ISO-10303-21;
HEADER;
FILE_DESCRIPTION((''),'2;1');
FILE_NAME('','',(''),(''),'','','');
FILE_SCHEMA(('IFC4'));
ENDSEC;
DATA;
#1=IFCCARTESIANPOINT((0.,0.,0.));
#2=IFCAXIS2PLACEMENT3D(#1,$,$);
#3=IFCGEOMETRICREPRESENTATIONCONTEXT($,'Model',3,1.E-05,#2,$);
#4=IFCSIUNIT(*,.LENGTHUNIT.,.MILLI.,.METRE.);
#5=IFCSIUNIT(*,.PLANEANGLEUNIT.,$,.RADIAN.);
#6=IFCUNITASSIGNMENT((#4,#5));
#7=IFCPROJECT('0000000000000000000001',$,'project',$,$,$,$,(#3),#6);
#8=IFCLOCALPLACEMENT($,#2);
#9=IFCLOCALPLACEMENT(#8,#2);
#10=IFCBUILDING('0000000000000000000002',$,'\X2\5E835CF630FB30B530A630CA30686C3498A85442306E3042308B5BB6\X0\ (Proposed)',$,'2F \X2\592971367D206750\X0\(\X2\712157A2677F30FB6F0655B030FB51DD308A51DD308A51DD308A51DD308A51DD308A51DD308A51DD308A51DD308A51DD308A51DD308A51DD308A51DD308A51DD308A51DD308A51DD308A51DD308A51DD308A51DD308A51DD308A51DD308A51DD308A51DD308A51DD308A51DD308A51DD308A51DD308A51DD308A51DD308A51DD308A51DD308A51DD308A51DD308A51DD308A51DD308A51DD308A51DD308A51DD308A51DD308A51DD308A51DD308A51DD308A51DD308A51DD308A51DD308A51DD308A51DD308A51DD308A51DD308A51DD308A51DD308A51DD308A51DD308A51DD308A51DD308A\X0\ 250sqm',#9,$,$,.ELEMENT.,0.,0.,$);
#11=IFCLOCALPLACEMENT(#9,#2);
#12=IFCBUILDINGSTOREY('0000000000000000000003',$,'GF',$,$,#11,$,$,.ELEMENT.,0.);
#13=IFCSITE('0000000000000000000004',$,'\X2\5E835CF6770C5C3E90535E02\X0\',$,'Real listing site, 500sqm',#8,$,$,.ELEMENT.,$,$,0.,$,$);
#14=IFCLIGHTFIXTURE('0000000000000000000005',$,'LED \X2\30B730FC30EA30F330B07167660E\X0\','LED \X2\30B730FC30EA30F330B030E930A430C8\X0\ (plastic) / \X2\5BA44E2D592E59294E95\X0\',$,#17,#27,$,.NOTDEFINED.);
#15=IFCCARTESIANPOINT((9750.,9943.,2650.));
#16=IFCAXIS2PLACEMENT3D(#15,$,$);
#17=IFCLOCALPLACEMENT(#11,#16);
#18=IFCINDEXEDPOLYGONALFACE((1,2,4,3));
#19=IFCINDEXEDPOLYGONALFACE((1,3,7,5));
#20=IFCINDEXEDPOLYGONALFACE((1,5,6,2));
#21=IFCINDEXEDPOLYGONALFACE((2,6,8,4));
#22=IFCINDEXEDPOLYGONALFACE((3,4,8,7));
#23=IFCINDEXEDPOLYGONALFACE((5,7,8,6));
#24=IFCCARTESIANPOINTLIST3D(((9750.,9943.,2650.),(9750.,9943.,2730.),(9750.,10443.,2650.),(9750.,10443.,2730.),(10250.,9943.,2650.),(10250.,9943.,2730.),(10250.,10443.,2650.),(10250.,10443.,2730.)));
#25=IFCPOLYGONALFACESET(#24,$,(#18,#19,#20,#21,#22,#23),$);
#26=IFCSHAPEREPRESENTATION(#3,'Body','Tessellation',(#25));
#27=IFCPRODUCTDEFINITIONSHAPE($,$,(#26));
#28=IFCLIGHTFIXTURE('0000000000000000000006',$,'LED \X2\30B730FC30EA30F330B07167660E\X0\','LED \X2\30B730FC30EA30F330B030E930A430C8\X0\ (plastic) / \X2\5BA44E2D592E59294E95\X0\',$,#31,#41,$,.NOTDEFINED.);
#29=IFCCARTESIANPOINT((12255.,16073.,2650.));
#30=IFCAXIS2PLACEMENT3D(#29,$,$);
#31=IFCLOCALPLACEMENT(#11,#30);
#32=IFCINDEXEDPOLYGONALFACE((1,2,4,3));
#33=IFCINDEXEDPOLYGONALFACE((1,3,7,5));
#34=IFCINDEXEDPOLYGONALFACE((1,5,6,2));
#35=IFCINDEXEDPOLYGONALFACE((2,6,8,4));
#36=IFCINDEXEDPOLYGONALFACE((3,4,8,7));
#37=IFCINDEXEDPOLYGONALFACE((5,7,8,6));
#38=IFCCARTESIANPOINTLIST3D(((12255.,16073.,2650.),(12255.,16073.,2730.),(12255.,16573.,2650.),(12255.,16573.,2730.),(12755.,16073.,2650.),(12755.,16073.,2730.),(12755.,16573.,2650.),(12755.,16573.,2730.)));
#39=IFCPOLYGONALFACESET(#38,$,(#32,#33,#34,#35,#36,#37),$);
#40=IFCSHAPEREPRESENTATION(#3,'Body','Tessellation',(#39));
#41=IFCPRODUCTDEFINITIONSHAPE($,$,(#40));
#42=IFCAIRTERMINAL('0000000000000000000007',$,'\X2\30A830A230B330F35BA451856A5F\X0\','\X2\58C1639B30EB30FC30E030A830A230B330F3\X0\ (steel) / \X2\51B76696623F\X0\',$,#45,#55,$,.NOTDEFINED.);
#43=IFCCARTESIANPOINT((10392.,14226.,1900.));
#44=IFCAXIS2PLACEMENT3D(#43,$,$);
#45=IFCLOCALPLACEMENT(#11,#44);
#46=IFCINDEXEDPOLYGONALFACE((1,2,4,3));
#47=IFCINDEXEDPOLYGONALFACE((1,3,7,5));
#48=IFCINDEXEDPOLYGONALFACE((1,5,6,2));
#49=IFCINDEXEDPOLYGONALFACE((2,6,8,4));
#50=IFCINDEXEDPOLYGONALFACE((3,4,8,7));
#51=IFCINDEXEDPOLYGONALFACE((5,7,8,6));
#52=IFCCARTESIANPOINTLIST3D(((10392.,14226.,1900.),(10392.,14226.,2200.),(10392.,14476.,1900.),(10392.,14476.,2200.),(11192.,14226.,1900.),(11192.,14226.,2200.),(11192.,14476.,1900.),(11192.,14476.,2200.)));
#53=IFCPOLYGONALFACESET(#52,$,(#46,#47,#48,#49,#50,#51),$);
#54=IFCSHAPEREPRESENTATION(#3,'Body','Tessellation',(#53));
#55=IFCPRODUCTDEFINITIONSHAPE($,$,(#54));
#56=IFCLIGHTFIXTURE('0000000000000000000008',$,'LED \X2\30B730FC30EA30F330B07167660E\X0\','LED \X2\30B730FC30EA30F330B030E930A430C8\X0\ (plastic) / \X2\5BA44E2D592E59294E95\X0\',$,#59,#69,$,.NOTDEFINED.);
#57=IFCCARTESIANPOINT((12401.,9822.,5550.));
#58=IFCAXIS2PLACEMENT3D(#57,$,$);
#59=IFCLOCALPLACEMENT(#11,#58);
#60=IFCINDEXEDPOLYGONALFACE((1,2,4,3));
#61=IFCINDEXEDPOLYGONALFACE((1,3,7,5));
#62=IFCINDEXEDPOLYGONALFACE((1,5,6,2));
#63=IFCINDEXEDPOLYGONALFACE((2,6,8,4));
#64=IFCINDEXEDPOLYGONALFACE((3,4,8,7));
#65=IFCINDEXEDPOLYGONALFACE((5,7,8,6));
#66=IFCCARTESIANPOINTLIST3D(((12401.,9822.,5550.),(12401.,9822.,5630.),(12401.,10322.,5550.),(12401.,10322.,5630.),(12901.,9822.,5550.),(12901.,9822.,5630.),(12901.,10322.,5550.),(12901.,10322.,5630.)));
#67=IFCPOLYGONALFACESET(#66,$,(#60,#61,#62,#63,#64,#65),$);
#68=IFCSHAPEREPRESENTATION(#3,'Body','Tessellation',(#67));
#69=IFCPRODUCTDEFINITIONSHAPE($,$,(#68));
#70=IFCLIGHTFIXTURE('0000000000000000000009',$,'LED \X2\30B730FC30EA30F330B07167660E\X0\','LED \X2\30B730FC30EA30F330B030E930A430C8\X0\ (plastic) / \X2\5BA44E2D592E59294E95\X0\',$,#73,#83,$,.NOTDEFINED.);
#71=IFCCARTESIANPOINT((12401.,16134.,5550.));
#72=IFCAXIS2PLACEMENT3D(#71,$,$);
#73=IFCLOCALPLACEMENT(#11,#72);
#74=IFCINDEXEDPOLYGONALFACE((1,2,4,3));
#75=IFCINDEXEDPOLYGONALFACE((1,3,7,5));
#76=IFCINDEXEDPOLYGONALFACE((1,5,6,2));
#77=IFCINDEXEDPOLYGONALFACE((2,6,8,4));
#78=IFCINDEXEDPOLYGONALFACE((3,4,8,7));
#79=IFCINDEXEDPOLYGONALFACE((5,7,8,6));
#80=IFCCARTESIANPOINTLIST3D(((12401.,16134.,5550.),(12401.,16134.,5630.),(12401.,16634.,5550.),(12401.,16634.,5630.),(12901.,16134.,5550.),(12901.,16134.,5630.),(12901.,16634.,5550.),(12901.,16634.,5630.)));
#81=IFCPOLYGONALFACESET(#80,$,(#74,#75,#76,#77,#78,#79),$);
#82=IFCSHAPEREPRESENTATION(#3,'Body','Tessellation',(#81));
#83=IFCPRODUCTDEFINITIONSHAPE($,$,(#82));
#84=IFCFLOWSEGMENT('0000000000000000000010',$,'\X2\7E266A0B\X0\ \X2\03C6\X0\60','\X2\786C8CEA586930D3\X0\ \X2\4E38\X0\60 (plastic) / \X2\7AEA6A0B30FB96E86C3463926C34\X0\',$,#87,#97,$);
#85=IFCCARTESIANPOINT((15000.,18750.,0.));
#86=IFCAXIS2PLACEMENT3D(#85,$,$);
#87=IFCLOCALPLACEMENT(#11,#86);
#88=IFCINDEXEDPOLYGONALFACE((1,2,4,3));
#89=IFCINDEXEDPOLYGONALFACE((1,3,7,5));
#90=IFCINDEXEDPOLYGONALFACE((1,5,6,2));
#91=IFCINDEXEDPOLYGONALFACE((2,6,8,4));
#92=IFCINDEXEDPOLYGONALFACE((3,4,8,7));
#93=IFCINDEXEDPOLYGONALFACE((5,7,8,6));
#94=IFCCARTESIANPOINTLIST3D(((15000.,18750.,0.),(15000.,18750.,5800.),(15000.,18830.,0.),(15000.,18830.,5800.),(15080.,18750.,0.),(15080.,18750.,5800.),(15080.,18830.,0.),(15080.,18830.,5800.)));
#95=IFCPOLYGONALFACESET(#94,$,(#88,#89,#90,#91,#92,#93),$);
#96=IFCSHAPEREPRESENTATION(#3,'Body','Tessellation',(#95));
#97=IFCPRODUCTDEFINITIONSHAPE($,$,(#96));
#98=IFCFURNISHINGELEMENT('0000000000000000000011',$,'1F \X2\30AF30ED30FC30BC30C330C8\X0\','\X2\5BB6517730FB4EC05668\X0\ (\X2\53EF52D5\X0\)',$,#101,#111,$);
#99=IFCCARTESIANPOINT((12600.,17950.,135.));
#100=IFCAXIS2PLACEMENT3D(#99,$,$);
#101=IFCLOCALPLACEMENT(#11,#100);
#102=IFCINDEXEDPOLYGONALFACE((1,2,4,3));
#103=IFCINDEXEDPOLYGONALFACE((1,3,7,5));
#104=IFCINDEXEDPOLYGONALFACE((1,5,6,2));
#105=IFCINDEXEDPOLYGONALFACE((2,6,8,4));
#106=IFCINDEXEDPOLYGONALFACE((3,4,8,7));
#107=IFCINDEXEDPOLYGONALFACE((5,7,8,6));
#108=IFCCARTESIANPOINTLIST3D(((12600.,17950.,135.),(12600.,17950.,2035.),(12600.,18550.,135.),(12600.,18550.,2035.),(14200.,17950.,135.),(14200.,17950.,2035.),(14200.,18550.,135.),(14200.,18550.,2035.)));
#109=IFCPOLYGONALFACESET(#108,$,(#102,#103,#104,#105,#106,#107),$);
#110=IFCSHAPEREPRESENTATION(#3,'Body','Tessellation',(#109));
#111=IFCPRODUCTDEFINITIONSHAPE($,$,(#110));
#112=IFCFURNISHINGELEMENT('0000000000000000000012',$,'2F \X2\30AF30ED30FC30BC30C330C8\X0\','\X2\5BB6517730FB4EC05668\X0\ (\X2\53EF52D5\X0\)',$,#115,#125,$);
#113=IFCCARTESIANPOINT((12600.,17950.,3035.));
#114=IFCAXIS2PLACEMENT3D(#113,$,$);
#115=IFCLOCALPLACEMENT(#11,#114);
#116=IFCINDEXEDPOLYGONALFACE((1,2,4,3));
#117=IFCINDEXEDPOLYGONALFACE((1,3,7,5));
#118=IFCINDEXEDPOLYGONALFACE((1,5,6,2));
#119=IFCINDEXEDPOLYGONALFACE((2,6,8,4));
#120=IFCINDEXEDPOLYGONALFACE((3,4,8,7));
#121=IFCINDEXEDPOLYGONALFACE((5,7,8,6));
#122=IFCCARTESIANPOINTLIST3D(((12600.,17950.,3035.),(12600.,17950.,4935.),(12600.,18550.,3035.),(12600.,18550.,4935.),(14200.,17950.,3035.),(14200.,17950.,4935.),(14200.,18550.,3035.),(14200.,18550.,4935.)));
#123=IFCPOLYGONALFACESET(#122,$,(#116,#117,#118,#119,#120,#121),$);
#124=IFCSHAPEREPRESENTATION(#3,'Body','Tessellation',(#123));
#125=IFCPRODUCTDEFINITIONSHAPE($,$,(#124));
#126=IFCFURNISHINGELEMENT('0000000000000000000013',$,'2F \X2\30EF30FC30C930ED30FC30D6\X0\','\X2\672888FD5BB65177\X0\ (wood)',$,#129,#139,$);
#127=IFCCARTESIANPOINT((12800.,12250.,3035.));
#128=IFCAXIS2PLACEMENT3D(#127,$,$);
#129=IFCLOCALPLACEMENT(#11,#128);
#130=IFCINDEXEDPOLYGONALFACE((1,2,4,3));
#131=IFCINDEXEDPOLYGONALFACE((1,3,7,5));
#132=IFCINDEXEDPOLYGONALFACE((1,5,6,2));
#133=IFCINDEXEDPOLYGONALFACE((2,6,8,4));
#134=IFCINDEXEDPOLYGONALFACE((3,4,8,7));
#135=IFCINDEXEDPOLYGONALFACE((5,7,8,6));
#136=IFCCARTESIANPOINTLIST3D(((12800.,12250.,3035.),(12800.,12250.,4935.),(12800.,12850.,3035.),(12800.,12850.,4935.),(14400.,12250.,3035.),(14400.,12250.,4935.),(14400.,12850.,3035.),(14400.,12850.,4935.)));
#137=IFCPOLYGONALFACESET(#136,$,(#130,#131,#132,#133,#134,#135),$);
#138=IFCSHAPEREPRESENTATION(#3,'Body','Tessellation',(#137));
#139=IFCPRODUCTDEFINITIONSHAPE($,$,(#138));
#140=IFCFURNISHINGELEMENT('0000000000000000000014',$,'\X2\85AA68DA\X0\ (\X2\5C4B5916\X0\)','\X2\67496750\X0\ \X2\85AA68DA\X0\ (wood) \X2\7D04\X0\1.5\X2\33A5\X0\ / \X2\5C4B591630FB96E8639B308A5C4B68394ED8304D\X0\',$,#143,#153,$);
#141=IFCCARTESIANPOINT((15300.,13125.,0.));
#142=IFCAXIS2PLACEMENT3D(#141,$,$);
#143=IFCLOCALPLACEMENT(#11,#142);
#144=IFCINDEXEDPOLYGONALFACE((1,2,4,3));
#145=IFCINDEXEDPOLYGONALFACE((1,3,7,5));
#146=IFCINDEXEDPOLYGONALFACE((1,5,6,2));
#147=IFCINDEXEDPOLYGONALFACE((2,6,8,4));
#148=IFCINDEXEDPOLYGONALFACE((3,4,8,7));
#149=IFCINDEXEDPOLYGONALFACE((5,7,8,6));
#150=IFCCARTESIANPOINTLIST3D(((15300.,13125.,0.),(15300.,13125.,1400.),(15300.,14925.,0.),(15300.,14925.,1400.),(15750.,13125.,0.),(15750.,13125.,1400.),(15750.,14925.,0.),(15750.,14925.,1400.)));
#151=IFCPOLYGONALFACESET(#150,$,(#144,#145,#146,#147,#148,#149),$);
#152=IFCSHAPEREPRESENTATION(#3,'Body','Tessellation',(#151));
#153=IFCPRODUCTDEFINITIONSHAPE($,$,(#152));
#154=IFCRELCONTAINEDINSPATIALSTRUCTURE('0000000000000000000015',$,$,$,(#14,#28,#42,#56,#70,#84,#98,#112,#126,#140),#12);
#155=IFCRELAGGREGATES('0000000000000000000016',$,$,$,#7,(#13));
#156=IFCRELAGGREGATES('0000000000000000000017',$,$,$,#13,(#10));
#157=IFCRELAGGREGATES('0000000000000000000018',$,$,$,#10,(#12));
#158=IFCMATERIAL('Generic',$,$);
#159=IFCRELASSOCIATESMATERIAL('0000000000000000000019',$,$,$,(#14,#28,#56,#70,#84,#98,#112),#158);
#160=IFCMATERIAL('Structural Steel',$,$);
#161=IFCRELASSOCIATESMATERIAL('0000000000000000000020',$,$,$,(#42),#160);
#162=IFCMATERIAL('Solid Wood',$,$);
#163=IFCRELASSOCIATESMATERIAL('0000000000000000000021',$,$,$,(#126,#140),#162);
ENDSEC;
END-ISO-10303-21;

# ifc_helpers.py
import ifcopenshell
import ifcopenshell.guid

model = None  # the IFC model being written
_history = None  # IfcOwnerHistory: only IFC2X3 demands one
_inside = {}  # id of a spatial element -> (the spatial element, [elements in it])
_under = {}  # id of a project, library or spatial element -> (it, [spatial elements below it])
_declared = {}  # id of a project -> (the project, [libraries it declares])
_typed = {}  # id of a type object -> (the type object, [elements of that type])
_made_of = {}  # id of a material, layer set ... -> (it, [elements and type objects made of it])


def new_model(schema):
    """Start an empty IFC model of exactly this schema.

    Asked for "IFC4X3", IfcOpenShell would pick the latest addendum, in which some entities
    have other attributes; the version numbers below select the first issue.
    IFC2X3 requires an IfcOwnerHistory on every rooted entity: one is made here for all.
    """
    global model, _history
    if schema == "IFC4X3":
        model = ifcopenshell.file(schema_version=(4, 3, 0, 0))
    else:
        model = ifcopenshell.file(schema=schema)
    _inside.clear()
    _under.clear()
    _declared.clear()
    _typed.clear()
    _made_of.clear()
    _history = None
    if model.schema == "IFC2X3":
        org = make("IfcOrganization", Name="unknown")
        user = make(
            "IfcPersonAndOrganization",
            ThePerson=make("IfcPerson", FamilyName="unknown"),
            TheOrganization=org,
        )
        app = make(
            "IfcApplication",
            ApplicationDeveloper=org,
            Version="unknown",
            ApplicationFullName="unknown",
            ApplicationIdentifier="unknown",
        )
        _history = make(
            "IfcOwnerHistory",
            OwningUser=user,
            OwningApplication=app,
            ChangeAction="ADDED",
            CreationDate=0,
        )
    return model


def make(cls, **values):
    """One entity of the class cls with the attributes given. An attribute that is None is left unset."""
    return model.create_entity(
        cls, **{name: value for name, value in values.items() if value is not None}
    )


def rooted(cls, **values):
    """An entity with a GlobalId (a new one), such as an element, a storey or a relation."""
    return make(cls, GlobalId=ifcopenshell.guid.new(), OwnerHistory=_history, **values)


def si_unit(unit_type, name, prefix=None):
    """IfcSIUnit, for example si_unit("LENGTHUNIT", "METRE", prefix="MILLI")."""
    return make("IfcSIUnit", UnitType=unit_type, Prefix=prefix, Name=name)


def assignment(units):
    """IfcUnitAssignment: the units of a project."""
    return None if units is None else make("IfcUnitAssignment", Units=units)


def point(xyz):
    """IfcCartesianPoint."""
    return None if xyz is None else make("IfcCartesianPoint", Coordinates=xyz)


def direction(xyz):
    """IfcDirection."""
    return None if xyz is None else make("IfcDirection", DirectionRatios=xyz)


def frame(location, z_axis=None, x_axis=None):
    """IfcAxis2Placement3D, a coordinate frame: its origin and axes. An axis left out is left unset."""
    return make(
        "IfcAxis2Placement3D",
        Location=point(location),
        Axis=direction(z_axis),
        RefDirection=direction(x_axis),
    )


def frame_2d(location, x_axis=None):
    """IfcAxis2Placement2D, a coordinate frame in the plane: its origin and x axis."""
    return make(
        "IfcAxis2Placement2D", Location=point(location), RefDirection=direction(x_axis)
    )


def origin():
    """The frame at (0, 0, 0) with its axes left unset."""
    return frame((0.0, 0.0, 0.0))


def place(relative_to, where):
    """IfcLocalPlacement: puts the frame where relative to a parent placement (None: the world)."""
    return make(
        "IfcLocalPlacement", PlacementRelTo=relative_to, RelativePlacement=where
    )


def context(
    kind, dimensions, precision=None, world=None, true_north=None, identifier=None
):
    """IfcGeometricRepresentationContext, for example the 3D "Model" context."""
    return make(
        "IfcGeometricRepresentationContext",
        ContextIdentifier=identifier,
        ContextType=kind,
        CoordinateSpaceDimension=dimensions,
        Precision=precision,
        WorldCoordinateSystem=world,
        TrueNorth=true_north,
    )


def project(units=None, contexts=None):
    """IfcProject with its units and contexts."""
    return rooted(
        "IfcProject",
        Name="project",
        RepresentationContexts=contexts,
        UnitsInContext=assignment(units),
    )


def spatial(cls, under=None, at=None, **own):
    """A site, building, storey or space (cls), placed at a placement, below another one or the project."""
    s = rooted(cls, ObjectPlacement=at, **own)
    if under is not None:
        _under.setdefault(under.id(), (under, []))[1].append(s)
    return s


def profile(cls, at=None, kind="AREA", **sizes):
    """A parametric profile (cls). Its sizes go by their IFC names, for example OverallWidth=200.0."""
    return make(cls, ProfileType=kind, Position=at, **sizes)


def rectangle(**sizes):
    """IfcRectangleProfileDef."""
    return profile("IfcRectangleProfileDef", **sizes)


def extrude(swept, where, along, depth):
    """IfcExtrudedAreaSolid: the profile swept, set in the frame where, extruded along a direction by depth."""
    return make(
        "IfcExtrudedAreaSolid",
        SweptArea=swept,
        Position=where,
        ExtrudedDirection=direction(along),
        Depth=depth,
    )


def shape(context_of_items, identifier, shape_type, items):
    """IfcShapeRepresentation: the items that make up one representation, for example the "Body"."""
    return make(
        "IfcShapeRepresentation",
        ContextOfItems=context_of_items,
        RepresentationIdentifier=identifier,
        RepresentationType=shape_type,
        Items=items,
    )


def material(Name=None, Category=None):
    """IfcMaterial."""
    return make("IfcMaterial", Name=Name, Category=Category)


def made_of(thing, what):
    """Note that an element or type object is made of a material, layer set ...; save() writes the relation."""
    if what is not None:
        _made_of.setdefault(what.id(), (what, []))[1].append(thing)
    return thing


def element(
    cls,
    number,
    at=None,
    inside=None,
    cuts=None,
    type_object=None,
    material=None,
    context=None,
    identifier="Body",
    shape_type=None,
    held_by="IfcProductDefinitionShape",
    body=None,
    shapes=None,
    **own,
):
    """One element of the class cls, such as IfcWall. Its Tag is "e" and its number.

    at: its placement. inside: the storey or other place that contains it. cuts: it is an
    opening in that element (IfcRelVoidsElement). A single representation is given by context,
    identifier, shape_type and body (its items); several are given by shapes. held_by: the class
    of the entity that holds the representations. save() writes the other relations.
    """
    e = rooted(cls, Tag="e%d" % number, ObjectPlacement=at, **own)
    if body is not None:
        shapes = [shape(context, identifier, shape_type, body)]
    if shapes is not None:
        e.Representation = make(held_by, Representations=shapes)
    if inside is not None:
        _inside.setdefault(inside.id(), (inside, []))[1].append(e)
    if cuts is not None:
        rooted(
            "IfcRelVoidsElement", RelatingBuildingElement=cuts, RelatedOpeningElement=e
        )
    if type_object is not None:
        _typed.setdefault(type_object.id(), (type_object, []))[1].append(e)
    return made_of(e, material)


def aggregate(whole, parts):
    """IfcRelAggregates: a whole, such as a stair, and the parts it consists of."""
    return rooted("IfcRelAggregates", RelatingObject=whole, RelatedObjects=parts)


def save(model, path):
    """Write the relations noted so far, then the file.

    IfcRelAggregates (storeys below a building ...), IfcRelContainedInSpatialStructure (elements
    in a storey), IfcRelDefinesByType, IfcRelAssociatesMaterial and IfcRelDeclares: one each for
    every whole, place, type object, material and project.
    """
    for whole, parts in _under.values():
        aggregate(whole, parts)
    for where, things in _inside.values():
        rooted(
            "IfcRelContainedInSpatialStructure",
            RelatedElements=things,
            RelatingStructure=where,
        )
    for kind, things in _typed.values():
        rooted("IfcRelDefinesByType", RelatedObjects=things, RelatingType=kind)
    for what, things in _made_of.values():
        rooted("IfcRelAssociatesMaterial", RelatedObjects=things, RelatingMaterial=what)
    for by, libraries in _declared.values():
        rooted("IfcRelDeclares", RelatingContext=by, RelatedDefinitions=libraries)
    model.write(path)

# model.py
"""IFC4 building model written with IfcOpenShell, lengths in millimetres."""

from ifc_helpers import new_model, si_unit, frame, frame_2d, origin, place, context, project, spatial, rectangle, extrude, material, element, save


model = new_model("IFC4")

# Units and contexts
model_context = context("Model", 3, precision=1e-05, world=origin())
ifc_project = project(units=[si_unit("LENGTHUNIT", "METRE", prefix="MILLI"), si_unit("PLANEANGLEUNIT", "RADIAN")], contexts=[model_context])

# Site, building, storey
site_placement = place(None, origin())
site = spatial("IfcSite", under=ifc_project, at=site_placement, Name="広島県尾道市", ObjectType="Real listing site, 500sqm", CompositionType="ELEMENT", RefElevation=0.0)
building_placement = place(site_placement, origin())
building = spatial("IfcBuilding", under=site, at=building_placement, Name="広島・サウナと水風呂のある家 (Proposed)", ObjectType="2F 天然素材(無垢板・漆喰・凝り凝り凝り凝り凝り凝り凝り凝り凝り凝り凝り凝り凝り凝り凝り凝り凝り凝り凝り凝り凝り凝り凝り凝り凝り凝り凝り凝り凝り凝り凝り凝り凝り凝り凝り凝り凝り凝り凝り凝り凝り凝り凝り凝り凝り凝り凝り凝り凝り凝り凝り凝り凝り凝り 250sqm", CompositionType="ELEMENT", ElevationOfRefHeight=0.0, ElevationOfTerrain=0.0)
storey_placement = place(building_placement, origin())
storey = spatial("IfcBuildingStorey", under=building, at=storey_placement, Name="GF", CompositionType="ELEMENT", Elevation=0.0)

# Shared definitions
ifc_material_1 = material(Name="Solid Wood")

# Shared definitions
ifc_material_2 = material(Name="Structural Steel")

# Shared definitions
ifc_material_3 = material(Name="Generic")

# Light fixtures
light_fixture_1_placement = place(storey_placement, frame((9750.0, 9943.0, 2650.0)))
element("IfcLightFixture", 1, at=light_fixture_1_placement, inside=storey, material=ifc_material_3, Name="LED シーリング照明", Description="LED シーリングライト (plastic) / 室中央天井", PredefinedType="NOTDEFINED", context=model_context, shape_type="SweptSolid", body=[
    extrude(rectangle(XDim=500.0, YDim=500.0, at=frame_2d((250.0, 250.0))), frame((9750.0, 9943.0, 2650.0)), (0.0, 0.0, 1.0), 80.0),
])
light_fixture_2_placement = place(storey_placement, frame((12255.0, 16073.0, 2650.0)))
element("IfcLightFixture", 2, at=light_fixture_2_placement, inside=storey, material=ifc_material_3, Name="LED シーリング照明", Description="LED シーリングライト (plastic) / 室中央天井", PredefinedType="NOTDEFINED", context=model_context, shape_type="SweptSolid", body=[
    extrude(rectangle(XDim=500.0, YDim=500.0, at=frame_2d((250.0, 250.0))), frame((12255.0, 16073.0, 2650.0)), (0.0, 0.0, 1.0), 80.0),
])

# Air terminal
air_terminal_placement = place(storey_placement, frame((10392.0, 14226.0, 1900.0)))
element("IfcAirTerminal", 3, at=air_terminal_placement, inside=storey, material=ifc_material_2, Name="エアコン室内機", Description="壁掛ルームエアコン (steel) / 冷暖房", PredefinedType="NOTDEFINED", context=model_context, shape_type="SweptSolid", body=[
    extrude(rectangle(XDim=800.0, YDim=250.0, at=frame_2d((400.0, 125.0))), frame((10392.0, 14226.0, 1900.0)), (0.0, 0.0, 1.0), 300.0),
])

# Light fixtures
light_fixture_3_placement = place(storey_placement, frame((12401.0, 9822.0, 5550.0)))
element("IfcLightFixture", 4, at=light_fixture_3_placement, inside=storey, material=ifc_material_3, Name="LED シーリング照明", Description="LED シーリングライト (plastic) / 室中央天井", PredefinedType="NOTDEFINED", context=model_context, shape_type="SweptSolid", body=[
    extrude(rectangle(XDim=500.0, YDim=500.0, at=frame_2d((250.0, 250.0))), frame((12401.0, 9822.0, 5550.0)), (0.0, 0.0, 1.0), 80.0),
])
light_fixture_4_placement = place(storey_placement, frame((12401.0, 16134.0, 5550.0)))
element("IfcLightFixture", 5, at=light_fixture_4_placement, inside=storey, material=ifc_material_3, Name="LED シーリング照明", Description="LED シーリングライト (plastic) / 室中央天井", PredefinedType="NOTDEFINED", context=model_context, shape_type="SweptSolid", body=[
    extrude(rectangle(XDim=500.0, YDim=500.0, at=frame_2d((250.0, 250.0))), frame((12401.0, 16134.0, 5550.0)), (0.0, 0.0, 1.0), 80.0),
])

# Flow segment
flow_segment_placement = place(storey_placement, frame((15000.0, 18750.0, 0.0)))
element("IfcFlowSegment", 6, at=flow_segment_placement, inside=storey, material=ifc_material_3, Name="縦樋 φ60", Description="硬質塩ビ 丸60 (plastic) / 竪樋・雨水排水", context=model_context, shape_type="SweptSolid", body=[
    extrude(rectangle(XDim=80.0, YDim=80.0, at=frame_2d((40.0, 40.0))), frame((15000.0, 18750.0, 0.0)), (0.0, 0.0, 1.0), 5800.0),
])

# Furnishing elements
furnishing_1_placement = place(storey_placement, frame((12600.0, 17950.0, 135.0)))
element("IfcFurnishingElement", 7, at=furnishing_1_placement, inside=storey, material=ifc_material_3, Name="1F クローゼット", Description="家具・什器 (可動)", context=model_context, shape_type="SweptSolid", body=[
    extrude(rectangle(XDim=1600.0, YDim=600.0, at=frame_2d((800.0, 300.0))), frame((12600.0, 17950.0, 135.0)), (0.0, 0.0, 1.0), 1900.0),
])
furnishing_2_placement = place(storey_placement, frame((12600.0, 17950.0, 3035.0)))
element("IfcFurnishingElement", 8, at=furnishing_2_placement, inside=storey, material=ifc_material_3, Name="2F クローゼット", Description="家具・什器 (可動)", context=model_context, shape_type="SweptSolid", body=[
    extrude(rectangle(XDim=1600.0, YDim=600.0, at=frame_2d((800.0, 300.0))), frame((12600.0, 17950.0, 3035.0)), (0.0, 0.0, 1.0), 1900.0),
])
furnishing_3_placement = place(storey_placement, frame((12800.0, 12250.0, 3035.0)))
element("IfcFurnishingElement", 9, at=furnishing_3_placement, inside=storey, material=ifc_material_1, Name="2F ワードローブ", Description="木製家具 (wood)", context=model_context, shape_type="SweptSolid", body=[
    extrude(rectangle(XDim=1600.0, YDim=600.0, at=frame_2d((800.0, 300.0))), frame((12800.0, 12250.0, 3035.0)), (0.0, 0.0, 1.0), 1900.0),
])
furnishing_4_placement = place(storey_placement, frame((15300.0, 13125.0, 0.0)))
element("IfcFurnishingElement", 10, at=furnishing_4_placement, inside=storey, material=ifc_material_1, Name="薪棚 (屋外)", Description="杉材 薪棚 (wood) 約1.5㎥ / 屋外・雨掛り屋根付き", context=model_context, shape_type="SweptSolid", body=[
    extrude(rectangle(XDim=450.0, YDim=1800.0, at=frame_2d((225.0, 900.0))), frame((15300.0, 13125.0, 0.0)), (0.0, 0.0, 1.0), 1400.0),
])

save(model, "model.ifc")
